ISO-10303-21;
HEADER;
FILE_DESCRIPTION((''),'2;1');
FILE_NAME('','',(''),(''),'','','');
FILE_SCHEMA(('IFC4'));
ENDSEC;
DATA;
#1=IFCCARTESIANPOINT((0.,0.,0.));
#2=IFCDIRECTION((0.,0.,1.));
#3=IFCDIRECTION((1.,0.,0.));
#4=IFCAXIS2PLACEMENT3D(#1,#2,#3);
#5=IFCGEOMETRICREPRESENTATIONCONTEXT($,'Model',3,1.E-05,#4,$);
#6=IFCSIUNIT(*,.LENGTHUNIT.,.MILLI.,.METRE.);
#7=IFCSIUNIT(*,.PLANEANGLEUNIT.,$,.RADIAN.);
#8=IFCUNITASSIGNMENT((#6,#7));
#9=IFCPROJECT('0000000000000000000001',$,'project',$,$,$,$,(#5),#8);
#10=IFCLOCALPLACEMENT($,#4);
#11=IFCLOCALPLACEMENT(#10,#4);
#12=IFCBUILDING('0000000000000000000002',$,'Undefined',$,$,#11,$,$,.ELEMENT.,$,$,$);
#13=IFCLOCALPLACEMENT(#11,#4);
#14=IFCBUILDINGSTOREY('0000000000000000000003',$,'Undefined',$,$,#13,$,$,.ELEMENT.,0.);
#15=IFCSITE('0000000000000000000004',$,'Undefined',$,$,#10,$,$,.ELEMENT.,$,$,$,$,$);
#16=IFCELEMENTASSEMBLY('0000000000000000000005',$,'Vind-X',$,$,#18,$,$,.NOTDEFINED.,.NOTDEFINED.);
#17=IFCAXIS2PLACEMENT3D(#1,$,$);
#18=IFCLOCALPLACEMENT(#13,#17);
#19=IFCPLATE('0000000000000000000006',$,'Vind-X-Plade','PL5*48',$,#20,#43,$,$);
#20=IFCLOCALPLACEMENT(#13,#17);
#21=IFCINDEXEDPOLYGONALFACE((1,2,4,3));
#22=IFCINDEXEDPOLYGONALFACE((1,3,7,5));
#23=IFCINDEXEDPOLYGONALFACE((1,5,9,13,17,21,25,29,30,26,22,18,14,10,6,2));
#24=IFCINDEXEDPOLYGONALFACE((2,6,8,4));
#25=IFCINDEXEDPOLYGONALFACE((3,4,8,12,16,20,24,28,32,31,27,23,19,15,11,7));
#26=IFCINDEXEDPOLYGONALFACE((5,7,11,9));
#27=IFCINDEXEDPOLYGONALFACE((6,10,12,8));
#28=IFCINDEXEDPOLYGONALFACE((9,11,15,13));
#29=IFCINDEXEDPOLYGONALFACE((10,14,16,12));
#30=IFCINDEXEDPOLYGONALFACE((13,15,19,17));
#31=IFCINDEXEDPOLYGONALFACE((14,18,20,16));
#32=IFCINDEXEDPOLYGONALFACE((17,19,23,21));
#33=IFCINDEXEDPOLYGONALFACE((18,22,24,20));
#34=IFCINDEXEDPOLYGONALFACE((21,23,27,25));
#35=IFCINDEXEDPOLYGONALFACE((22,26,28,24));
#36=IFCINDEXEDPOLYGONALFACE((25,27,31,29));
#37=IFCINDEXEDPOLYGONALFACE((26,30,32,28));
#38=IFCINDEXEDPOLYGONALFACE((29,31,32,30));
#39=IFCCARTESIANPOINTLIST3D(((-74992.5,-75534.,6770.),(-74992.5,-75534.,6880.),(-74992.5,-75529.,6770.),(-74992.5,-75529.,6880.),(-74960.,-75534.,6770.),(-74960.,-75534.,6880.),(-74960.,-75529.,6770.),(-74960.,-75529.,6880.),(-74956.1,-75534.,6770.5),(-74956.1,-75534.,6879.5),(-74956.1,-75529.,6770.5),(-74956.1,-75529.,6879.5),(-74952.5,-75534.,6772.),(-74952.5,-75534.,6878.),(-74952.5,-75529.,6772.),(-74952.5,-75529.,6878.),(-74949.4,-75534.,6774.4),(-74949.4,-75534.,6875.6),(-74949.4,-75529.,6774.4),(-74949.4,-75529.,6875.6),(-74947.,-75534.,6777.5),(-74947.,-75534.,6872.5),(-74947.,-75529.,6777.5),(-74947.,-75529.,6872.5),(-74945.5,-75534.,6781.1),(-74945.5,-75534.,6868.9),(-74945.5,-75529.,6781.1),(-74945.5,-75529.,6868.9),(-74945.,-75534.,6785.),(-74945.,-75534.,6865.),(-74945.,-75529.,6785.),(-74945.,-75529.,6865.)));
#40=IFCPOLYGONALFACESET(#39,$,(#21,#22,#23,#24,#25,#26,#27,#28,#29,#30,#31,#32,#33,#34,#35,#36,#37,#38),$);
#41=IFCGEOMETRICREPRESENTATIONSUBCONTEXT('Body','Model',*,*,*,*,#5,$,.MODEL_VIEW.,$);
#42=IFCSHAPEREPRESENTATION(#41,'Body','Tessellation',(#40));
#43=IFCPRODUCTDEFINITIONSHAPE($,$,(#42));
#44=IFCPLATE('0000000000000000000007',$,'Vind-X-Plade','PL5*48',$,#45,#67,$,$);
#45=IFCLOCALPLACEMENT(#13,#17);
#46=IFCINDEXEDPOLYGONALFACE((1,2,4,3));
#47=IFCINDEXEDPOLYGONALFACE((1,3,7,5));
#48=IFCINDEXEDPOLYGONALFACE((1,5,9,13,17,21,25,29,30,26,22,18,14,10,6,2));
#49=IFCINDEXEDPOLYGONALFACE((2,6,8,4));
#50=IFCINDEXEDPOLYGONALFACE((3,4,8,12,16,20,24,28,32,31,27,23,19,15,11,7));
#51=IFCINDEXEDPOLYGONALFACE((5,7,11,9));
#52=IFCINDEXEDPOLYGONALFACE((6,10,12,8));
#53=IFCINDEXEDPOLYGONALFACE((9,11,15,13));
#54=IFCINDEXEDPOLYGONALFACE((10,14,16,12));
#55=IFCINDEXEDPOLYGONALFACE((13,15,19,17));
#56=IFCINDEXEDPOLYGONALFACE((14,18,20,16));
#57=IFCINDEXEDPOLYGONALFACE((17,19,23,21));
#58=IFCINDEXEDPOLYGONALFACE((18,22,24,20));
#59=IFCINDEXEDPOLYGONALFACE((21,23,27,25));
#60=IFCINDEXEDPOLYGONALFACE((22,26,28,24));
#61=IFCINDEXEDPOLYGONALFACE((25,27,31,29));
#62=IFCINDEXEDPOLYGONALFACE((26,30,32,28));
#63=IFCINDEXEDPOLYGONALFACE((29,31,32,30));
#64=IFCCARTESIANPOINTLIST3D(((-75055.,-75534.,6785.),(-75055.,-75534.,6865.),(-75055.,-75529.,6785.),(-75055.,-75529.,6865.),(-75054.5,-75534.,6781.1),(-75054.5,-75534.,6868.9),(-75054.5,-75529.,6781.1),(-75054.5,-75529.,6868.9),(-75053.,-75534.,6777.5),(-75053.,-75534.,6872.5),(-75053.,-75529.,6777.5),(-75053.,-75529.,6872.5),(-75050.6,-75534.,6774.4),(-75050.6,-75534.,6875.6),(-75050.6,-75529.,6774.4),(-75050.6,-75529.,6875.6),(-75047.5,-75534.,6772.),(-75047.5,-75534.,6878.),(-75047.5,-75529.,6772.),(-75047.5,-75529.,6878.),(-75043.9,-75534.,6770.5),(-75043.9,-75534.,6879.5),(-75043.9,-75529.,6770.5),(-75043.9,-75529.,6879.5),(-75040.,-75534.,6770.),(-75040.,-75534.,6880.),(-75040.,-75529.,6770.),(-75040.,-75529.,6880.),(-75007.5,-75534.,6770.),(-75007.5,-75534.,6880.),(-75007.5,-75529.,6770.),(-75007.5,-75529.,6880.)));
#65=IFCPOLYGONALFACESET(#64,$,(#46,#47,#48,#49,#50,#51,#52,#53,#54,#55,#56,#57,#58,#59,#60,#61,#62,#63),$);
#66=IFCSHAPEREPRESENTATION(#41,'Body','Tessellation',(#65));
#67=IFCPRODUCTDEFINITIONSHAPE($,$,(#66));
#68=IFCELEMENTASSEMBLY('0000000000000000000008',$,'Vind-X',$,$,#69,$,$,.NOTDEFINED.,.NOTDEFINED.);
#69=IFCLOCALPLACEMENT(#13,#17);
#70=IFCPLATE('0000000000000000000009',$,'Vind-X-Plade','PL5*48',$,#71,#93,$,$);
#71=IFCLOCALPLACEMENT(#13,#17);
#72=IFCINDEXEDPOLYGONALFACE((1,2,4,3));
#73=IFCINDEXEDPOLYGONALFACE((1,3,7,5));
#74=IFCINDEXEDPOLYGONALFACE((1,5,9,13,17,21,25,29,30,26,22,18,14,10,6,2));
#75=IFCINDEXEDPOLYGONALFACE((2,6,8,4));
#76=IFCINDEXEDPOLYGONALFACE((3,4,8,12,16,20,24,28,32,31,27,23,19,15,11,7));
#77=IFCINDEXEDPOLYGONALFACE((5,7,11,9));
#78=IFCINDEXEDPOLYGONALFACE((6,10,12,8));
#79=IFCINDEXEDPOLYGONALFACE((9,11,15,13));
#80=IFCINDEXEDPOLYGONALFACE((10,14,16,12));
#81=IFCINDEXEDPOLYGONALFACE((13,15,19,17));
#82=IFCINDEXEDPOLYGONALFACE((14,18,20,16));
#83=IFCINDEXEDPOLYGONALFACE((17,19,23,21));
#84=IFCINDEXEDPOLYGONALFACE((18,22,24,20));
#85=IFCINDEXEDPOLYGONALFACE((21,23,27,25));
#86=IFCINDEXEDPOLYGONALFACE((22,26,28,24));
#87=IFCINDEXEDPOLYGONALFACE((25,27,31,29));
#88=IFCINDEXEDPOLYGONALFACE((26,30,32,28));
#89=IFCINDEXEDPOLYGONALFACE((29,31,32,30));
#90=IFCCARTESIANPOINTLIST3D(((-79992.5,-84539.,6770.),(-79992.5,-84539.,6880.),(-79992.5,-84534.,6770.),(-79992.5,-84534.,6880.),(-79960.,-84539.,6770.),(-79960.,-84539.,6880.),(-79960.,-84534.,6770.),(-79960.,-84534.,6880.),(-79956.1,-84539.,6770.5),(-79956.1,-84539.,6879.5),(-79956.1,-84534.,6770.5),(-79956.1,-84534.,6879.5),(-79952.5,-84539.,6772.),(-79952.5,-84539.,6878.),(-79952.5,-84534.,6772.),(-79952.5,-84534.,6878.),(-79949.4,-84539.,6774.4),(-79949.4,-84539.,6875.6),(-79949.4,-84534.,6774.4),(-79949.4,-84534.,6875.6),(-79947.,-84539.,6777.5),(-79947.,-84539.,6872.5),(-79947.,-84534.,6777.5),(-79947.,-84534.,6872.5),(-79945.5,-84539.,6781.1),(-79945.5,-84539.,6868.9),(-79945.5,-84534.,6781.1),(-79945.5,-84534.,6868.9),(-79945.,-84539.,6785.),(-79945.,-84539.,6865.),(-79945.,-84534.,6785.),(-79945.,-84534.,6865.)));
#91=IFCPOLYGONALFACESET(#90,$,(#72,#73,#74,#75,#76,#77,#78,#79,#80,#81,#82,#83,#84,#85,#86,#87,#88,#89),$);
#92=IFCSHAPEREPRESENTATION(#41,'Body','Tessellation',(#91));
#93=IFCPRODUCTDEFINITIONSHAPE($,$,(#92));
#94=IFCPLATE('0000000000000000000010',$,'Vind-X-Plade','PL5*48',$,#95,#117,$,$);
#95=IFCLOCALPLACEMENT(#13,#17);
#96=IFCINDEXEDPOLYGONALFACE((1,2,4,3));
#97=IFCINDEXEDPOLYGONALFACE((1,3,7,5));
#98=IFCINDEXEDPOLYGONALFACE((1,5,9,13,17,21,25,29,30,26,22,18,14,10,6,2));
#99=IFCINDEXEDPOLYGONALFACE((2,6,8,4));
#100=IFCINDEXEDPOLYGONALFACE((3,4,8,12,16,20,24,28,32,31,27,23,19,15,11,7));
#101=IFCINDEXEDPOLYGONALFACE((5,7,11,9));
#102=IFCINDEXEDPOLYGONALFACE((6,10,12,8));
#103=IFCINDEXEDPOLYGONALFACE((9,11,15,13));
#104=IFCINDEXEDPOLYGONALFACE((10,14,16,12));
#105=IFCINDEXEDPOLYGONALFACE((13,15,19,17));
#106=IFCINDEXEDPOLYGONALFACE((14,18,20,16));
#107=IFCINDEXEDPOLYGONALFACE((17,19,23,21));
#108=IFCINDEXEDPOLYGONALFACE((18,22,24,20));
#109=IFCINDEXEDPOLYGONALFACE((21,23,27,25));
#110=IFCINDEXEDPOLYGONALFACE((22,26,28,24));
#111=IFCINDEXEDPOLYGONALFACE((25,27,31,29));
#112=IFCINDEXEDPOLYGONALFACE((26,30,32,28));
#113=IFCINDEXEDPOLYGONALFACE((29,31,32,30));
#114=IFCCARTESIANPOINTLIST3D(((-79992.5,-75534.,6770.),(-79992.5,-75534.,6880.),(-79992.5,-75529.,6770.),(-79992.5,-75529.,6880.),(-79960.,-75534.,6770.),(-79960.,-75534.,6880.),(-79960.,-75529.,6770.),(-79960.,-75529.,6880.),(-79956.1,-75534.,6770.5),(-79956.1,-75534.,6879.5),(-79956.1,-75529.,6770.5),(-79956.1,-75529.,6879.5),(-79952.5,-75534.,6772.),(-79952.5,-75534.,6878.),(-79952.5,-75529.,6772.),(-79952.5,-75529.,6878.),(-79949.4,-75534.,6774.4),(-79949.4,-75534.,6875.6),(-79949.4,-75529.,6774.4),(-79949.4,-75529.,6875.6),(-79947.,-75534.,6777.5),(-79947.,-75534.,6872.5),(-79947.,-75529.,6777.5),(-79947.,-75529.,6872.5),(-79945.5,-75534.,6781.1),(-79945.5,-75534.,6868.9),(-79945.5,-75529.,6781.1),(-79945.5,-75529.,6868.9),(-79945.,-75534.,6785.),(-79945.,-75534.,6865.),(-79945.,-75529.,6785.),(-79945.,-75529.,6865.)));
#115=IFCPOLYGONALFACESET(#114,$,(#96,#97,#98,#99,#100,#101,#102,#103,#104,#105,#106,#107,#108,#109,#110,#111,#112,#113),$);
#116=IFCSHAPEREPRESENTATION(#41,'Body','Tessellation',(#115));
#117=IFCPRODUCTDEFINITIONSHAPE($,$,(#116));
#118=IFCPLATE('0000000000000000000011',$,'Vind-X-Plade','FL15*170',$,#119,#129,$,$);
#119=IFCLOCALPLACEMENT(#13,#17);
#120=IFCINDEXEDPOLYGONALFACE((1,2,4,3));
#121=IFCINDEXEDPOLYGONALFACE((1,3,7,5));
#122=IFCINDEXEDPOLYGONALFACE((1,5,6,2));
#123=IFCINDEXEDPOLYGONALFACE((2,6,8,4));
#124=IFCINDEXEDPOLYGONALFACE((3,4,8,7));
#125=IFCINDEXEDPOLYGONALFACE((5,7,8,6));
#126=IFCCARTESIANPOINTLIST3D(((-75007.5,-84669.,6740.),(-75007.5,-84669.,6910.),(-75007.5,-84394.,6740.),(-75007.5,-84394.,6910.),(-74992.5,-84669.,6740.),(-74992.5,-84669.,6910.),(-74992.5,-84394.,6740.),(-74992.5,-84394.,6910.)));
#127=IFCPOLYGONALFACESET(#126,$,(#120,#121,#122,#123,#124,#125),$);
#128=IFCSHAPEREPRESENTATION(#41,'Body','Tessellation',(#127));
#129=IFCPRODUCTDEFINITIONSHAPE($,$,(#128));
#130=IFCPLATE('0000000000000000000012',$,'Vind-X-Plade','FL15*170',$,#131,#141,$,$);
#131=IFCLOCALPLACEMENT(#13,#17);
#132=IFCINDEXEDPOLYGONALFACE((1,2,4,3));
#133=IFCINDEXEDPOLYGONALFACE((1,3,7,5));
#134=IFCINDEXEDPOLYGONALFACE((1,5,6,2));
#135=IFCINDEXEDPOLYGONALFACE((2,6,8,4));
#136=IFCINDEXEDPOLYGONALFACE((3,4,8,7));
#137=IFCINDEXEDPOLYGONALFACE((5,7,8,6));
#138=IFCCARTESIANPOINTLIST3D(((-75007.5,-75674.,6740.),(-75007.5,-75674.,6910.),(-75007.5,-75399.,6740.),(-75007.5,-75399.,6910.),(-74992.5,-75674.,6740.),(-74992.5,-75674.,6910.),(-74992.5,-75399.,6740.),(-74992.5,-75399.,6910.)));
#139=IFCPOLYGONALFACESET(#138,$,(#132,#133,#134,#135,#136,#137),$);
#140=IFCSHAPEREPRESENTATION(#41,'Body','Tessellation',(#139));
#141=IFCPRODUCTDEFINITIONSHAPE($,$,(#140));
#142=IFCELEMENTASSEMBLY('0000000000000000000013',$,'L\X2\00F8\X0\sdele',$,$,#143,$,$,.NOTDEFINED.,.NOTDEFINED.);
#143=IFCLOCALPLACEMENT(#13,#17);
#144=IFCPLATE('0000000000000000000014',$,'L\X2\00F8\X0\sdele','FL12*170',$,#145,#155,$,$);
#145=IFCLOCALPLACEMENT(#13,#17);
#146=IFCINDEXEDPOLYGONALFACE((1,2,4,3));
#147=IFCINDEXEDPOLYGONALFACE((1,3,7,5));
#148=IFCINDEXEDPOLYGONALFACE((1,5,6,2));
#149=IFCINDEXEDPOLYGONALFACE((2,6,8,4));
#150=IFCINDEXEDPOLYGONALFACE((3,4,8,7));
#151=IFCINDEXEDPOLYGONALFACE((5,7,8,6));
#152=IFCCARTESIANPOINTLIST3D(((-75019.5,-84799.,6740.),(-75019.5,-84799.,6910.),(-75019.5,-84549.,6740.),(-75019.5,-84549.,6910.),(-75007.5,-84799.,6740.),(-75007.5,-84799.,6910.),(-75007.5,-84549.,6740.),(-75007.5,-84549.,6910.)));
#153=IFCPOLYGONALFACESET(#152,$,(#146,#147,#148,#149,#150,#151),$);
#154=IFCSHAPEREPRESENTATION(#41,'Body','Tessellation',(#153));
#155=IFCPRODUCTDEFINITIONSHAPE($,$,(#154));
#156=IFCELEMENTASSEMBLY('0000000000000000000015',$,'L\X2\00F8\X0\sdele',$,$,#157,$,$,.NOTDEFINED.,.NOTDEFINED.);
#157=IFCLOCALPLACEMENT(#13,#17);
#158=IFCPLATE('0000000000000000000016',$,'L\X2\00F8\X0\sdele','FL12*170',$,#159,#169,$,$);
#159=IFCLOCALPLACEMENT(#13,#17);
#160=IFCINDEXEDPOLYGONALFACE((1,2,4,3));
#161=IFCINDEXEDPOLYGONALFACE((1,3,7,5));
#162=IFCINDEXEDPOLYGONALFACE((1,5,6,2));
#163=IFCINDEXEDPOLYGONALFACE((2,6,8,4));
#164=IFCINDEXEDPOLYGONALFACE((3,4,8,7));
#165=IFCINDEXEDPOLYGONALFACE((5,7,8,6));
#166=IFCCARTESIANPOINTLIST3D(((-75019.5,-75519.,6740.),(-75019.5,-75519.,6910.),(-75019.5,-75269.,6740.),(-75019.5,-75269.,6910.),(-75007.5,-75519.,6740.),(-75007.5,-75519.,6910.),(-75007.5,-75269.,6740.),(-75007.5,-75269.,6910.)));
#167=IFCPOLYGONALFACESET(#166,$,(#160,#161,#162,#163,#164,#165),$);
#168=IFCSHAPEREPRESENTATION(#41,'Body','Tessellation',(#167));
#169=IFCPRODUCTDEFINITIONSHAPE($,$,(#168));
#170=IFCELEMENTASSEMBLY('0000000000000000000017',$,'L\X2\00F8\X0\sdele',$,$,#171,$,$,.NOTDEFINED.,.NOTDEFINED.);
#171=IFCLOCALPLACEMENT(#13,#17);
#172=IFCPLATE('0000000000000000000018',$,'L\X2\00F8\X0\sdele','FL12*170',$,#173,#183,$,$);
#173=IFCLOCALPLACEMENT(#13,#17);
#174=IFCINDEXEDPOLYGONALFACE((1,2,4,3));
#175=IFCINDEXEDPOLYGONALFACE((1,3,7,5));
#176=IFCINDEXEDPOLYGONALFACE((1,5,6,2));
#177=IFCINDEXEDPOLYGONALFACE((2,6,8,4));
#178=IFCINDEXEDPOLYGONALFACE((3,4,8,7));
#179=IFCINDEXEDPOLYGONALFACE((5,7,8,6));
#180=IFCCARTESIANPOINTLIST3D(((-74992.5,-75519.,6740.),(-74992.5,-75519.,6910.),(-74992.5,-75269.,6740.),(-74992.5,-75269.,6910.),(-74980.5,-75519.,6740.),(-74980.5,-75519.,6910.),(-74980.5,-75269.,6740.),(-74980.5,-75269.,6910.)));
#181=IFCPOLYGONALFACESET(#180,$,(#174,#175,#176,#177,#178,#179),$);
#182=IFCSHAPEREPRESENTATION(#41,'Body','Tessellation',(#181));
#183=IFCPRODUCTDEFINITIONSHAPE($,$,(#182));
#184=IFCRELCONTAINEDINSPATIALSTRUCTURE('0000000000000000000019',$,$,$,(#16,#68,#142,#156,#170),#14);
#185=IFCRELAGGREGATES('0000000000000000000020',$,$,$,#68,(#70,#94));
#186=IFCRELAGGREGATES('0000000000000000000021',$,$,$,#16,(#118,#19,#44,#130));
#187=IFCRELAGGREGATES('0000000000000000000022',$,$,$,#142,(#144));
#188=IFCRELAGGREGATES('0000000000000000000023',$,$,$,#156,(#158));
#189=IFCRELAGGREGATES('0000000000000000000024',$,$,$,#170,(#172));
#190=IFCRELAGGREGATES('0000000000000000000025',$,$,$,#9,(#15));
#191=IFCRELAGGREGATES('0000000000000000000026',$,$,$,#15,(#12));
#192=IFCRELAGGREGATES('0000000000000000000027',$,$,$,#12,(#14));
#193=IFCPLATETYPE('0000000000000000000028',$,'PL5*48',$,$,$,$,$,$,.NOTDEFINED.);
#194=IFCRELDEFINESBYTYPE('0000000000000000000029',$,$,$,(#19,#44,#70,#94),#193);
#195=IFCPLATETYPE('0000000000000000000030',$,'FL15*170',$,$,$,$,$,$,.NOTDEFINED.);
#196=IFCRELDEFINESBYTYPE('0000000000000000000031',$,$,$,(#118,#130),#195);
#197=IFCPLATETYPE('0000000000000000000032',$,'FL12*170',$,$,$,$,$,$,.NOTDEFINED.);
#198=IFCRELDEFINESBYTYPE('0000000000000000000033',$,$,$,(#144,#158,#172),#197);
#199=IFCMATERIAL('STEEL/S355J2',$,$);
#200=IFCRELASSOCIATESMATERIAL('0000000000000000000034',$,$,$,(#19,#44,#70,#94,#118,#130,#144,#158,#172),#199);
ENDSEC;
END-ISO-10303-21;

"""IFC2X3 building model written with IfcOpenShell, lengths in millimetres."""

from ifc_helpers import new_model, si_unit, frame, frame_2d, origin_with_axes, place, context, subcontext, project, spatial, polyline, circle_curve, parameter, trimmed, segment, composite_curve, outline, extrude, material, type_object, element, aggregate, save


model = new_model("IFC2X3")

# Units and contexts
model_context = context("Model", 3, precision=1e-05, world=origin_with_axes())
body_context = subcontext(model_context, "Body", "Model", "MODEL_VIEW")
ifc_project = project(units=[si_unit("LENGTHUNIT", "METRE", prefix="MILLI"), si_unit("PLANEANGLEUNIT", "RADIAN")], contexts=[model_context])

# Site, building, storey
site_placement = place(None, origin_with_axes())
site = spatial("IfcSite", under=ifc_project, at=site_placement, Name="Undefined", CompositionType="ELEMENT")
building_placement = place(site_placement, origin_with_axes())
building = spatial("IfcBuilding", under=site, at=building_placement, Name="Undefined", CompositionType="ELEMENT")
storey_placement = place(building_placement, origin_with_axes())
storey = spatial("IfcBuildingStorey", under=building, at=storey_placement, Name="Undefined", CompositionType="ELEMENT", Elevation=0.0)

# Shared definitions
ifc_material_1 = material(Name="STEEL/S355J2")

# Element assemblies, plates
assembly_1_placement = place(storey_placement, origin_with_axes())
assembly_1 = element("IfcElementAssembly", 1, at=assembly_1_placement, inside=storey, Name="Vind-X", AssemblyPlace="NOTDEFINED", PredefinedType="NOTDEFINED")
plate_type_1 = type_object("IfcPlateType", Name="PL5*48", PredefinedType="NOTDEFINED")
plate_1_placement = place(assembly_1_placement, frame((-74945.0, -75531.5, 6880.0), z_axis=(0.0, -1.0, 0.0), x_axis=(-1.0, 0.0, 0.0)))
plate_1 = element("IfcPlate", 2, at=plate_1_placement, type_object=plate_type_1, material=ifc_material_1, Name="Vind-X-Plade", Description="PL5*48", context=body_context, shape_type="SweptSolid", body=[
    extrude(outline(composite_curve([segment(trimmed(circle_curve(frame_2d((15.0, 15.0), x_axis=(-1.0, 0.0)), 15.0), [parameter(0.0)], [parameter(1.570796)], True, "PARAMETER"), True, "CONTINUOUS"), segment(polyline([(15.0, 0.0), (47.5, 0.0), (47.5, 110.0), (15.0, 110.0)]), True, "CONTINUOUS"), segment(trimmed(circle_curve(frame_2d((15.0, 95.0), x_axis=(0.0, 1.0)), 15.0), [parameter(0.0)], [parameter(1.570796)], True, "PARAMETER"), True, "CONTINUOUS"), segment(polyline([(0.0, 95.0), (0.0, 15.0)]), True, "CONTINUOUS")], self_intersect=True)), frame((0.0, 0.0, -2.5), z_axis=(0.0, 0.0, 1.0), x_axis=(1.0, 0.0, 0.0)), (0.0, 0.0, 1.0), 5.0),
])
plate_2_placement = place(assembly_1_placement, frame((-75007.5, -75531.5, 6880.0), z_axis=(0.0, -1.0, 0.0), x_axis=(-1.0, 0.0, 0.0)))
plate_2 = element("IfcPlate", 3, at=plate_2_placement, type_object=plate_type_1, material=ifc_material_1, Name="Vind-X-Plade", Description="PL5*48", context=body_context, shape_type="SweptSolid", body=[
    extrude(outline(composite_curve([segment(polyline([(0.0, 0.0), (32.5, 0.0)]), True, "CONTINUOUS"), segment(trimmed(circle_curve(frame_2d((32.5, 15.0), x_axis=(0.0, -1.0)), 15.0), [parameter(0.0)], [parameter(1.570796)], True, "PARAMETER"), True, "CONTINUOUS"), segment(polyline([(47.5, 15.0), (47.5, 95.0)]), True, "CONTINUOUS"), segment(trimmed(circle_curve(frame_2d((32.5, 95.0), x_axis=(1.0, 0.0)), 15.0), [parameter(0.0)], [parameter(1.570796)], True, "PARAMETER"), True, "CONTINUOUS"), segment(polyline([(32.5, 110.0), (0.0, 110.0), (0.0, 0.0)]), True, "CONTINUOUS")], self_intersect=True)), frame((0.0, 0.0, -2.5), z_axis=(0.0, 0.0, 1.0), x_axis=(1.0, 0.0, 0.0)), (0.0, 0.0, 1.0), 5.0),
])
assembly_2_placement = place(storey_placement, origin_with_axes())
assembly_2 = element("IfcElementAssembly", 4, at=assembly_2_placement, inside=storey, Name="Vind-X", AssemblyPlace="NOTDEFINED", PredefinedType="NOTDEFINED")
plate_3_placement = place(assembly_2_placement, frame((-79945.0, -84536.5, 6770.0), z_axis=(0.0, 1.0, 0.0), x_axis=(-1.0, 0.0, 0.0)))
plate_3 = element("IfcPlate", 5, at=plate_3_placement, type_object=plate_type_1, material=ifc_material_1, Name="Vind-X-Plade", Description="PL5*48", context=body_context, shape_type="SweptSolid", body=[
    extrude(outline(composite_curve([segment(trimmed(circle_curve(frame_2d((15.0, 15.0), x_axis=(-1.0, 0.0)), 15.0), [parameter(0.0)], [parameter(1.570796)], True, "PARAMETER"), True, "CONTINUOUS"), segment(polyline([(15.0, 0.0), (47.5, 0.0), (47.5, 110.0), (15.0, 110.0)]), True, "CONTINUOUS"), segment(trimmed(circle_curve(frame_2d((15.0, 95.0), x_axis=(0.0, 1.0)), 15.0), [parameter(0.0)], [parameter(1.570796)], True, "PARAMETER"), True, "CONTINUOUS"), segment(polyline([(0.0, 95.0), (0.0, 15.0)]), True, "CONTINUOUS")], self_intersect=True)), frame((0.0, 0.0, -2.5), z_axis=(0.0, 0.0, 1.0), x_axis=(1.0, 0.0, 0.0)), (0.0, 0.0, 1.0), 5.0),
])
plate_4_placement = place(assembly_2_placement, frame((-79945.0, -75531.5, 6880.0), z_axis=(0.0, -1.0, 0.0), x_axis=(-1.0, 0.0, 0.0)))
plate_4 = element("IfcPlate", 6, at=plate_4_placement, type_object=plate_type_1, material=ifc_material_1, Name="Vind-X-Plade", Description="PL5*48", context=body_context, shape_type="SweptSolid", body=[
    extrude(outline(composite_curve([segment(trimmed(circle_curve(frame_2d((15.0, 15.0), x_axis=(-1.0, 0.0)), 15.0), [parameter(0.0)], [parameter(1.570796)], True, "PARAMETER"), True, "CONTINUOUS"), segment(polyline([(15.0, 0.0), (47.5, 0.0), (47.5, 110.0), (15.0, 110.0)]), True, "CONTINUOUS"), segment(trimmed(circle_curve(frame_2d((15.0, 95.0), x_axis=(0.0, 1.0)), 15.0), [parameter(0.0)], [parameter(1.570796)], True, "PARAMETER"), True, "CONTINUOUS"), segment(polyline([(0.0, 95.0), (0.0, 15.0)]), True, "CONTINUOUS")], self_intersect=True)), frame((0.0, 0.0, -2.5), z_axis=(0.0, 0.0, 1.0), x_axis=(1.0, 0.0, 0.0)), (0.0, 0.0, 1.0), 5.0),
])
aggregate(assembly_2, [plate_3, plate_4])

# Plates
plate_type_2 = type_object("IfcPlateType", Name="FL15*170", PredefinedType="NOTDEFINED")
plate_5_placement = place(assembly_1_placement, frame((-75000.0, -84669.0, 6825.0), z_axis=(1.0, 0.0, 0.0), x_axis=(0.0, 1.0, 0.0)))
plate_5 = element("IfcPlate", 7, at=plate_5_placement, type_object=plate_type_2, material=ifc_material_1, Name="Vind-X-Plade", Description="FL15*170", context=body_context, shape_type="SweptSolid", body=[
    extrude(outline(polyline([(0.0, -85.0), (0.0, 85.0), (275.0, 85.0), (275.0, -85.0), (0.0, -85.0)])), frame((0.0, 0.0, -7.5), z_axis=(0.0, 0.0, 1.0), x_axis=(1.0, 0.0, 0.0)), (0.0, 0.0, 1.0), 15.0),
])
plate_6_placement = place(assembly_1_placement, frame((-75000.0, -75399.0, 6825.0), z_axis=(1.0, 0.0, 0.0), x_axis=(0.0, -1.0, 0.0)))
plate_6 = element("IfcPlate", 8, at=plate_6_placement, type_object=plate_type_2, material=ifc_material_1, Name="Vind-X-Plade", Description="FL15*170", context=body_context, shape_type="SweptSolid", body=[
    extrude(outline(polyline([(0.0, -85.0), (0.0, 85.0), (275.0, 85.0), (275.0, -85.0), (0.0, -85.0)])), frame((0.0, 0.0, -7.5), z_axis=(0.0, 0.0, 1.0), x_axis=(1.0, 0.0, 0.0)), (0.0, 0.0, 1.0), 15.0),
])
aggregate(assembly_1, [plate_5, plate_1, plate_2, plate_6])

# Element assemblies, plates
assembly_3_placement = place(storey_placement, origin_with_axes())
assembly_3 = element("IfcElementAssembly", 9, at=assembly_3_placement, inside=storey, Name="Løsdele", AssemblyPlace="NOTDEFINED", PredefinedType="NOTDEFINED")
plate_type_3 = type_object("IfcPlateType", Name="FL12*170", PredefinedType="NOTDEFINED")
plate_7_placement = place(assembly_3_placement, frame((-75013.5, -84799.0, 6825.0), z_axis=(-1.0, 0.0, 0.0), x_axis=(0.0, 1.0, 0.0)))
plate_7 = element("IfcPlate", 10, at=plate_7_placement, type_object=plate_type_3, material=ifc_material_1, Name="Løsdele", Description="FL12*170", context=body_context, shape_type="SweptSolid", body=[
    extrude(outline(polyline([(0.0, -85.0), (0.0, 85.0), (250.0, 85.0), (250.0, -85.0), (0.0, -85.0)])), frame((0.0, 0.0, -6.0), z_axis=(0.0, 0.0, 1.0), x_axis=(1.0, 0.0, 0.0)), (0.0, 0.0, 1.0), 12.0),
])
aggregate(assembly_3, [plate_7])
assembly_4_placement = place(storey_placement, origin_with_axes())
assembly_4 = element("IfcElementAssembly", 11, at=assembly_4_placement, inside=storey, Name="Løsdele", AssemblyPlace="NOTDEFINED", PredefinedType="NOTDEFINED")
plate_8_placement = place(assembly_4_placement, frame((-75013.5, -75269.0, 6825.0), z_axis=(-1.0, 0.0, 0.0), x_axis=(0.0, -1.0, 0.0)))
plate_8 = element("IfcPlate", 12, at=plate_8_placement, type_object=plate_type_3, material=ifc_material_1, Name="Løsdele", Description="FL12*170", context=body_context, shape_type="SweptSolid", body=[
    extrude(outline(polyline([(0.0, -85.0), (0.0, 85.0), (250.0, 85.0), (250.0, -85.0), (0.0, -85.0)])), frame((0.0, 0.0, -6.0), z_axis=(0.0, 0.0, 1.0), x_axis=(1.0, 0.0, 0.0)), (0.0, 0.0, 1.0), 12.0),
])
aggregate(assembly_4, [plate_8])
assembly_5_placement = place(storey_placement, origin_with_axes())
assembly_5 = element("IfcElementAssembly", 13, at=assembly_5_placement, inside=storey, Name="Løsdele", AssemblyPlace="NOTDEFINED", PredefinedType="NOTDEFINED")
plate_9_placement = place(assembly_5_placement, frame((-74986.5, -75269.0, 6825.0), z_axis=(-1.0, 0.0, 0.0), x_axis=(0.0, -1.0, 0.0)))
plate_9 = element("IfcPlate", 14, at=plate_9_placement, type_object=plate_type_3, material=ifc_material_1, Name="Løsdele", Description="FL12*170", context=body_context, shape_type="SweptSolid", body=[
    extrude(outline(polyline([(0.0, -85.0), (0.0, 85.0), (250.0, 85.0), (250.0, -85.0), (0.0, -85.0)])), frame((0.0, 0.0, -6.0), z_axis=(0.0, 0.0, 1.0), x_axis=(1.0, 0.0, 0.0)), (0.0, 0.0, 1.0), 12.0),
])

aggregate(assembly_5, [plate_9])

save(model, "model.ifc")
